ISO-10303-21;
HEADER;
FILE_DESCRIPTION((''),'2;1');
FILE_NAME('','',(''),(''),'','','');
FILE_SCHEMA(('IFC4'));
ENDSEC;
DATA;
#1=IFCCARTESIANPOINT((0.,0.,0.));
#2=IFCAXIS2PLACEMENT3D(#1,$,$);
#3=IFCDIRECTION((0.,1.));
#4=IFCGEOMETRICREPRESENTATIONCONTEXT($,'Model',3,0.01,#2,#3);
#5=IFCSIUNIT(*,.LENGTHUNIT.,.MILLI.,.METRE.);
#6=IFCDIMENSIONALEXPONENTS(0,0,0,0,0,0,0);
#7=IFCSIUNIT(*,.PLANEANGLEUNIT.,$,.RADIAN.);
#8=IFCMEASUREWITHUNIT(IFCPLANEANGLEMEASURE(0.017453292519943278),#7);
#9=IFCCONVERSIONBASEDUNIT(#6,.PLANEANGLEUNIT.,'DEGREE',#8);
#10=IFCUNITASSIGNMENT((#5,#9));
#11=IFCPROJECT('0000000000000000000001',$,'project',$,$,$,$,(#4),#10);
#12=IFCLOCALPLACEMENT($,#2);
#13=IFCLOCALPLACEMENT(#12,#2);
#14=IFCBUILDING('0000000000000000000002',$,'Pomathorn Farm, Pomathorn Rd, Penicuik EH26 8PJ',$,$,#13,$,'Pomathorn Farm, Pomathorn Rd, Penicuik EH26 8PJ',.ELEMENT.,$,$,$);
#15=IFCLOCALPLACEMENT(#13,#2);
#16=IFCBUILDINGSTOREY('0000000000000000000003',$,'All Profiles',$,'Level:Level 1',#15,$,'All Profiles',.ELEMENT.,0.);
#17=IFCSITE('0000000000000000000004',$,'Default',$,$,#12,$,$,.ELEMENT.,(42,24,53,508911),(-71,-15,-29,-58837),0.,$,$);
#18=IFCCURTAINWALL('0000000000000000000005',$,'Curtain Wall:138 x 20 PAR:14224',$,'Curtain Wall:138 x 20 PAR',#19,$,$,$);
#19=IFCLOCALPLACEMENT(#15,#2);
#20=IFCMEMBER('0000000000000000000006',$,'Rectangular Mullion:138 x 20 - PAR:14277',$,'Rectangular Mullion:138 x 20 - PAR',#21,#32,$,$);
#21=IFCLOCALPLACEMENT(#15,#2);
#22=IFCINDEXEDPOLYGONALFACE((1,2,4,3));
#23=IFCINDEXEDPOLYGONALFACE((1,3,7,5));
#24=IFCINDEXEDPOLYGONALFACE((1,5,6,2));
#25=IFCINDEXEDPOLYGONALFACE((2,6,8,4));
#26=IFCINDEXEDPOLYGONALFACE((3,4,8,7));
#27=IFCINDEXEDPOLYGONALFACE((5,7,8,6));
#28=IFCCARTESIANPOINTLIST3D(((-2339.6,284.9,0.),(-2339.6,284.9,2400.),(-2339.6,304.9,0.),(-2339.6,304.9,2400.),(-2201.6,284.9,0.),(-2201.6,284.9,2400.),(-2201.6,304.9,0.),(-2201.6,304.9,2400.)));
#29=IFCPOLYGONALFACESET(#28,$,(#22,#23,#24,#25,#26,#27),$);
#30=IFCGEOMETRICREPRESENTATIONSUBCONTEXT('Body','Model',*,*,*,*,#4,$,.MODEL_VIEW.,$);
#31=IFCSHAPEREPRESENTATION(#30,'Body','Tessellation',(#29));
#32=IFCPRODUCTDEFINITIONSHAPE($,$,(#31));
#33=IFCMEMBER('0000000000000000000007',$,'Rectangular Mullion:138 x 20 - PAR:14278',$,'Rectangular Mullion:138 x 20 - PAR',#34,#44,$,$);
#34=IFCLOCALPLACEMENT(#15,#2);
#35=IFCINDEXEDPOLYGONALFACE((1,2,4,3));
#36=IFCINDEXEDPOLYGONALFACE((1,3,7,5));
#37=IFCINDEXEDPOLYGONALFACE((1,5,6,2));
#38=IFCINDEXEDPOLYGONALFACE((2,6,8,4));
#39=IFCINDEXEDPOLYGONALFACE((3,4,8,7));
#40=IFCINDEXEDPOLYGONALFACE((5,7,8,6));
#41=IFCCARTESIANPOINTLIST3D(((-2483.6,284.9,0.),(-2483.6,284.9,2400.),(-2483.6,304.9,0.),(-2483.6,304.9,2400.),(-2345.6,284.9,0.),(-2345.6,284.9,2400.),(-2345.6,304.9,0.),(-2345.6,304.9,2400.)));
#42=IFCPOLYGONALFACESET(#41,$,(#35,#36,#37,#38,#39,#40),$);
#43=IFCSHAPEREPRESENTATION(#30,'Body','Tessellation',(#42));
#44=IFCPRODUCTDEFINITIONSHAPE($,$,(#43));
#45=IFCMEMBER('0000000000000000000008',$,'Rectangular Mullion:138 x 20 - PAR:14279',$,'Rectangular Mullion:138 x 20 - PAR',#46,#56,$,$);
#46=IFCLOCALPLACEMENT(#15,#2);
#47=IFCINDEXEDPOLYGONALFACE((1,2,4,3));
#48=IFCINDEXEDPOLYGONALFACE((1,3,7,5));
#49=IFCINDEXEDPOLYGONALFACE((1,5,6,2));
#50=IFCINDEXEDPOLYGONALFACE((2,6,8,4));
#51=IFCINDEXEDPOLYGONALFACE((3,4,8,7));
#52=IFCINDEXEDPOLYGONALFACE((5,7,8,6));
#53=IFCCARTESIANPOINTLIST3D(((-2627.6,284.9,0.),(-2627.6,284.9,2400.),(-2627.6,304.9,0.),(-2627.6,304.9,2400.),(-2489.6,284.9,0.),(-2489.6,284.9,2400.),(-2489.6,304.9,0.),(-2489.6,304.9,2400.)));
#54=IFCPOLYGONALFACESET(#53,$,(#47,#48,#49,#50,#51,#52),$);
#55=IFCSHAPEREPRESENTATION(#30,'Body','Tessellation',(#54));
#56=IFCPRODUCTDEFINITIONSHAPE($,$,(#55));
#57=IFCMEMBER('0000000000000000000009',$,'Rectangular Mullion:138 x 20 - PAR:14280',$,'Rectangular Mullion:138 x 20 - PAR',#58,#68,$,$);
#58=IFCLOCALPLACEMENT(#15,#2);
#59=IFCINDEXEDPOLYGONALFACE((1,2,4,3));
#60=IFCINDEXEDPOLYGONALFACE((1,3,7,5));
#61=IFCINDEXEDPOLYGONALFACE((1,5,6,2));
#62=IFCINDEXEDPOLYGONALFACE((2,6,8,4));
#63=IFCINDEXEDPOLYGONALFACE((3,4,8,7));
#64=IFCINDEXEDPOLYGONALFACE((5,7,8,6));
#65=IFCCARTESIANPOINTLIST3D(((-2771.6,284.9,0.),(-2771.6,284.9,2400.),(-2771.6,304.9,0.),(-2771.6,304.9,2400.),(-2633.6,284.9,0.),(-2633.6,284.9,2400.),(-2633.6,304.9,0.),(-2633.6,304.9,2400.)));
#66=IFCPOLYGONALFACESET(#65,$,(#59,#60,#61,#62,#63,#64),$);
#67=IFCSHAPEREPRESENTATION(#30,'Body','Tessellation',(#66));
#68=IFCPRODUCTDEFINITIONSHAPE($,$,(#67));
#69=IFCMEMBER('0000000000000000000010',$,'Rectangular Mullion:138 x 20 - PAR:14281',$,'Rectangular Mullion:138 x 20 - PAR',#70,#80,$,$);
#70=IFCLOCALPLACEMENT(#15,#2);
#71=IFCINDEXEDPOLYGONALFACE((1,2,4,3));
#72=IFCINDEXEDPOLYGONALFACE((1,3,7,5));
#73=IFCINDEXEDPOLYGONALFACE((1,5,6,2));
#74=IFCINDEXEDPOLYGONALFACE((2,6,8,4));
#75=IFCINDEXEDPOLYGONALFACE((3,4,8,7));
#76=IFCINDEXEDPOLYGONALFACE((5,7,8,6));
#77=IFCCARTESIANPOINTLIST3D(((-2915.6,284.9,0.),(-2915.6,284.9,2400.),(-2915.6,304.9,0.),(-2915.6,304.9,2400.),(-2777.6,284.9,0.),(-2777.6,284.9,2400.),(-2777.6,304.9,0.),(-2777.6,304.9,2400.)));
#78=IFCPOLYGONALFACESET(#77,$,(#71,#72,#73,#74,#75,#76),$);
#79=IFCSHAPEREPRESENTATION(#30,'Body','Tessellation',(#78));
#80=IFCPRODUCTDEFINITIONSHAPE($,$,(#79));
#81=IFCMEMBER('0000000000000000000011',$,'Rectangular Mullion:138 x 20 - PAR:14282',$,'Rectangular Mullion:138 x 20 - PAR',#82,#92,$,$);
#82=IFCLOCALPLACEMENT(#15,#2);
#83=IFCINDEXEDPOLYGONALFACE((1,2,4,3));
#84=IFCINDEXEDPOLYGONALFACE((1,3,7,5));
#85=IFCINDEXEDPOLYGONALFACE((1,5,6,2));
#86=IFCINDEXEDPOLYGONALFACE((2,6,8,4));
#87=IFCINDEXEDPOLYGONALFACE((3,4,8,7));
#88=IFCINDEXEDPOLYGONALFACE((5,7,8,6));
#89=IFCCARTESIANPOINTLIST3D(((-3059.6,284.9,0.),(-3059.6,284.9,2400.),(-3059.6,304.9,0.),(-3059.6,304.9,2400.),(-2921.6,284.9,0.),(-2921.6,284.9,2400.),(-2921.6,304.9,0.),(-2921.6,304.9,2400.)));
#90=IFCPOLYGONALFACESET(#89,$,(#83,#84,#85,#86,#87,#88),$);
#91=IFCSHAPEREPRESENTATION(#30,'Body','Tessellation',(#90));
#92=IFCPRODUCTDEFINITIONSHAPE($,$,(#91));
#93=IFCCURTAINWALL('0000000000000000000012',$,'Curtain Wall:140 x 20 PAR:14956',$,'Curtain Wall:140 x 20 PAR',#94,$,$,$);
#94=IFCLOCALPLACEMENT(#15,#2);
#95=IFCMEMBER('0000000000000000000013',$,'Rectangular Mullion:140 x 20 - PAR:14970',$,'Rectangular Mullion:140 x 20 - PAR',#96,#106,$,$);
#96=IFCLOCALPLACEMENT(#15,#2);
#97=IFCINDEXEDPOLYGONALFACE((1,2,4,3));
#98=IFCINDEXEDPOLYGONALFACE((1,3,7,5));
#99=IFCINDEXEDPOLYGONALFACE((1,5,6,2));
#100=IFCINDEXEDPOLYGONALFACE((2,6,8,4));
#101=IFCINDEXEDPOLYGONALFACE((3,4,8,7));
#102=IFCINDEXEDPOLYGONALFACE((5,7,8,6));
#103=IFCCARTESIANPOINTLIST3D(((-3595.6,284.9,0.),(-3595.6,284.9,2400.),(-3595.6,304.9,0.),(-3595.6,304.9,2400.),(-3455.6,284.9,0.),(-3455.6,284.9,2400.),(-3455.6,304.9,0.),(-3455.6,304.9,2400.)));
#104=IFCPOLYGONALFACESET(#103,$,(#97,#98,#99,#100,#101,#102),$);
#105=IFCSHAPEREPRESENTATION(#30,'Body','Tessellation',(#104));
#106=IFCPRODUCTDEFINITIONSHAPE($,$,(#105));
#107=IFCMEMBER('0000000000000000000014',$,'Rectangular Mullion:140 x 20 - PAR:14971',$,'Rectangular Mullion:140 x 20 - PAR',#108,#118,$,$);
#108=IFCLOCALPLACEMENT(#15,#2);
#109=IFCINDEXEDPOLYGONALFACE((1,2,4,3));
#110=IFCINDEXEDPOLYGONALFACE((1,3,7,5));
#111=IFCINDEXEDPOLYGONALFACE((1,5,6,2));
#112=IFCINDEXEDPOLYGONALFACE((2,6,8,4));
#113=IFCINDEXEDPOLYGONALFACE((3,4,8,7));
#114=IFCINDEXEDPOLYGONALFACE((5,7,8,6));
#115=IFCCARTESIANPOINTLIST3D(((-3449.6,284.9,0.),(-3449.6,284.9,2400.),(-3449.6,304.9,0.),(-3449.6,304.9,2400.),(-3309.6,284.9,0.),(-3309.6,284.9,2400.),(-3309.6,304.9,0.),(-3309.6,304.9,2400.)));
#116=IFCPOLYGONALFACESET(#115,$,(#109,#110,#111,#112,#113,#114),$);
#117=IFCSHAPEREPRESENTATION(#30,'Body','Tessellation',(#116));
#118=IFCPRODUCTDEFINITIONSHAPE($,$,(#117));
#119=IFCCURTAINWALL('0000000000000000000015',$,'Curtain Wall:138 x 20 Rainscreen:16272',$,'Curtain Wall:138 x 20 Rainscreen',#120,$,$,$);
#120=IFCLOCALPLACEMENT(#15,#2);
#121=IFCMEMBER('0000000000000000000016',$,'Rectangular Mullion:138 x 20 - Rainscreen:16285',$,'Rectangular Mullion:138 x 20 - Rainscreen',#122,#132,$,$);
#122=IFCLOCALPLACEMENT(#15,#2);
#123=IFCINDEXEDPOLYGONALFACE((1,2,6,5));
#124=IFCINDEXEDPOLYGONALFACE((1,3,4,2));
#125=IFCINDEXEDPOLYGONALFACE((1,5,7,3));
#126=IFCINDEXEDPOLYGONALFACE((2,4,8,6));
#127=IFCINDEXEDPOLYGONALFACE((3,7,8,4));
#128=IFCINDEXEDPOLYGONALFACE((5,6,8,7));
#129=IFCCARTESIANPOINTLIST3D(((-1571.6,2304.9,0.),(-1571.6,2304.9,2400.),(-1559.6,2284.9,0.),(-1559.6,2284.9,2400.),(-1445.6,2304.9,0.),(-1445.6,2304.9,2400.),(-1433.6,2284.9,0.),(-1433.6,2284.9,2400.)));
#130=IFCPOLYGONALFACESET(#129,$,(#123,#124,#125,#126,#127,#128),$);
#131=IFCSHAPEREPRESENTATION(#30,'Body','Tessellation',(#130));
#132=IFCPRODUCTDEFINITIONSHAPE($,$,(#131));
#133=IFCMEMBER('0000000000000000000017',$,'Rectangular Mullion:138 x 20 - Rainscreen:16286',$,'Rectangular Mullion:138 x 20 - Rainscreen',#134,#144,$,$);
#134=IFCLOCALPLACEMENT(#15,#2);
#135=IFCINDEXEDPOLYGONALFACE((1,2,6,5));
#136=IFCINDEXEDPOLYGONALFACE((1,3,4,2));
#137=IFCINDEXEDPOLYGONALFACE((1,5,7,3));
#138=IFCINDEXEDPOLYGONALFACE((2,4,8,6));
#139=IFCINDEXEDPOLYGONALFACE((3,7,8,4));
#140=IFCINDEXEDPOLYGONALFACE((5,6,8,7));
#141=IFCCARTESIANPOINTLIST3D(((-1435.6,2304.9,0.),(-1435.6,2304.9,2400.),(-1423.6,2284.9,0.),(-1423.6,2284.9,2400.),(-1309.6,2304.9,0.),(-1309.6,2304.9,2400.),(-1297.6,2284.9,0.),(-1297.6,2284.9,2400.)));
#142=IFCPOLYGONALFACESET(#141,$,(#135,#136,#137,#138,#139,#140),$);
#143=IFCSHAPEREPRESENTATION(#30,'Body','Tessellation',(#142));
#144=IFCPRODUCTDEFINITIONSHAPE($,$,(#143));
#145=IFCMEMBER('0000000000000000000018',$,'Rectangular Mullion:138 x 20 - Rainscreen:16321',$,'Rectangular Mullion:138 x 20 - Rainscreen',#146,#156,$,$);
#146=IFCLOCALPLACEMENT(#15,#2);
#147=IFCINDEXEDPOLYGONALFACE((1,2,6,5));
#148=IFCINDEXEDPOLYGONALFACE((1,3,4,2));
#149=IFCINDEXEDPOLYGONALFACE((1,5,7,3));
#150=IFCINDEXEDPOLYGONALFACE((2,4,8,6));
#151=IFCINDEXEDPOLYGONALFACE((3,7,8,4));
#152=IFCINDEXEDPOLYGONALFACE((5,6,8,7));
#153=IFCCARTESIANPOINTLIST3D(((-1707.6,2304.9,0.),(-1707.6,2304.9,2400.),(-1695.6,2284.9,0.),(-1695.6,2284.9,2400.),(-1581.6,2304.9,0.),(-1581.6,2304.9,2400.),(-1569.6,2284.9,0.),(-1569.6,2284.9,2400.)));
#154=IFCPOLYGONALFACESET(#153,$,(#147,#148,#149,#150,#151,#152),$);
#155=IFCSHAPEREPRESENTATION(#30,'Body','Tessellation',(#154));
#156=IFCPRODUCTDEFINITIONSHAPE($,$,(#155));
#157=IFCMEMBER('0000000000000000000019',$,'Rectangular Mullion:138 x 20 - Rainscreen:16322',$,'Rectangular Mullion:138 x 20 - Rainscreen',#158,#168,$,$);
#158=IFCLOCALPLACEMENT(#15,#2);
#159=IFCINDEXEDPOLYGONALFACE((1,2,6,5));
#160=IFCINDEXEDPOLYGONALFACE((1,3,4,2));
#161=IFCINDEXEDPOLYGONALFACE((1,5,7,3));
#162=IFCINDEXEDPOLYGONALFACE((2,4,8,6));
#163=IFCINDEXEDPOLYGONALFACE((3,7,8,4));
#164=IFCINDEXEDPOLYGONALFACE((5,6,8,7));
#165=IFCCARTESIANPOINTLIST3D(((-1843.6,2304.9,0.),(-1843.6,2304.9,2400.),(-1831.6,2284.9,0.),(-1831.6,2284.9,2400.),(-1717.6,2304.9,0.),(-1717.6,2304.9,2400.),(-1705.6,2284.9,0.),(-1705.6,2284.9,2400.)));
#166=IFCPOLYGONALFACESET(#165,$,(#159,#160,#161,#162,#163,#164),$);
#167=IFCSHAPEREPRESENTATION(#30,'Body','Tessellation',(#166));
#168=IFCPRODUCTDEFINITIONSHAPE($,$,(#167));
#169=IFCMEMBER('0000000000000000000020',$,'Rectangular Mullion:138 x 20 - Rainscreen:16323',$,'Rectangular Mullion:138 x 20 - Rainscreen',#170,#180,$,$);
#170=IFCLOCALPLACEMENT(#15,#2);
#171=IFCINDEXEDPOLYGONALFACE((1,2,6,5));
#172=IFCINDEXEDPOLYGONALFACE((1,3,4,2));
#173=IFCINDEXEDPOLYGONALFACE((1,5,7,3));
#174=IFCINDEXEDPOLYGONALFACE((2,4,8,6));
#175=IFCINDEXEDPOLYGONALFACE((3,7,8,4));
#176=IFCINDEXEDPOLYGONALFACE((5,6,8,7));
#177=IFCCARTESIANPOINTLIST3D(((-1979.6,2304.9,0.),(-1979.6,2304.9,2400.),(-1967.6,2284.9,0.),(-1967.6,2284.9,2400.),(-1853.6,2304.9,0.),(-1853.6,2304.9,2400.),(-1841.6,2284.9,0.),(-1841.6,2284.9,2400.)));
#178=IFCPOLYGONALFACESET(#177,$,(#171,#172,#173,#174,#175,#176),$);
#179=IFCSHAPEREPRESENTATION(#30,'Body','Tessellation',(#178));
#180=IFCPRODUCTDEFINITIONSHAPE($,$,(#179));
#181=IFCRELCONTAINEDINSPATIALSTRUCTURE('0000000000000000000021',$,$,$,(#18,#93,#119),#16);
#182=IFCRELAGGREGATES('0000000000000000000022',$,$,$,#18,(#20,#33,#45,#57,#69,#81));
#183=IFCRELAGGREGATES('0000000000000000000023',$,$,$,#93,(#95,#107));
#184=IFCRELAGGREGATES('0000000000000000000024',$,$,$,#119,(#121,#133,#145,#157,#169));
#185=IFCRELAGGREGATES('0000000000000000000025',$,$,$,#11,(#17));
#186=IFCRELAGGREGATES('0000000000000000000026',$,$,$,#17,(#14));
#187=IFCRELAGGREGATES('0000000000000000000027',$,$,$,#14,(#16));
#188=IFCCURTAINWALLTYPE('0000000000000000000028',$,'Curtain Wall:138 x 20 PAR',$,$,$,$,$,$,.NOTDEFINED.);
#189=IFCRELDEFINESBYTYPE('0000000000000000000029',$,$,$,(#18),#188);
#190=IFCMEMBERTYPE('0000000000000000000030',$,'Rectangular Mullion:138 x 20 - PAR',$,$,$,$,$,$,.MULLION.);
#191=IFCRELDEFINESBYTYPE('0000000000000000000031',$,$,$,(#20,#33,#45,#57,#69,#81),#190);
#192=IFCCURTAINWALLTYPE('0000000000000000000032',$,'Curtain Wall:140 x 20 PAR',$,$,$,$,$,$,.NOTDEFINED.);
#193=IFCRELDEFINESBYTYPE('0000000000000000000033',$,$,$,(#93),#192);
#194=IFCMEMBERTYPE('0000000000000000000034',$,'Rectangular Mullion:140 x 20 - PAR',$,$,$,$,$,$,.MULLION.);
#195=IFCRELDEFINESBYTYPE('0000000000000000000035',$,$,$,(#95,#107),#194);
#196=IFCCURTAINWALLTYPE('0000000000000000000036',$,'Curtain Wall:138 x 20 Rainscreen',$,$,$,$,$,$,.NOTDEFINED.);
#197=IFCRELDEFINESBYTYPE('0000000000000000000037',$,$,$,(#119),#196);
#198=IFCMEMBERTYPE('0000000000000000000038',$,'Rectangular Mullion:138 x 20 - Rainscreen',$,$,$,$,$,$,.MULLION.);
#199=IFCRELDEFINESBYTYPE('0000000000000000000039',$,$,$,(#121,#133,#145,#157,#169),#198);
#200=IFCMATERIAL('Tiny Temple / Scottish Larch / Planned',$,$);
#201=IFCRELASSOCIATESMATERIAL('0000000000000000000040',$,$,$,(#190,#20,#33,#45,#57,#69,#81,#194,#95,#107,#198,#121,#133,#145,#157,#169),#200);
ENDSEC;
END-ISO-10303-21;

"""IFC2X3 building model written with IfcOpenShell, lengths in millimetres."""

from ifc_helpers import new_model, entity, si_unit, converted_unit, direction, frame, frame_2d, origin, place, context, subcontext, project, spatial, polyline, rectangle, outline, extrude, source, transform, mapped, material, type_object, type_shapes, element, aggregate, save


model = new_model("IFC2X3")

# Units and contexts
model_context = context("Model", 3, precision=0.01, world=origin(), true_north=direction((0.0, 1.0)))
body_context = subcontext(model_context, "Body", "Model", "MODEL_VIEW")
ifc_project = project(units=[si_unit("LENGTHUNIT", "METRE", prefix="MILLI"), converted_unit("PLANEANGLEUNIT", "DEGREE", entity("IfcPlaneAngleMeasure", 0.017453292519943278), si_unit("PLANEANGLEUNIT", "RADIAN"), dimensions=[0, 0, 0, 0, 0, 0, 0])], contexts=[model_context])

# Site, building, storey
site_placement = place(None, origin())
site = spatial("IfcSite", under=ifc_project, at=site_placement, Name="Default", CompositionType="ELEMENT", RefLatitude=(42, 24, 53, 508911), RefLongitude=(-71, -15, -29, -58837), RefElevation=0.0)
building_placement = place(site_placement, origin())
building = spatial("IfcBuilding", under=site, at=building_placement, Name="Pomathorn Farm, Pomathorn Rd, Penicuik EH26 8PJ", LongName="Pomathorn Farm, Pomathorn Rd, Penicuik EH26 8PJ", CompositionType="ELEMENT")
storey_placement = place(building_placement, origin())
storey = spatial("IfcBuildingStorey", under=building, at=storey_placement, Name="All Profiles", ObjectType="Level:Level 1", LongName="All Profiles", CompositionType="ELEMENT", Elevation=0.0)

# Curtain walls, members
curtain_wall_type_1 = type_object("IfcCurtainWallType", Name="Curtain Wall:138 x 20 PAR", PredefinedType="NOTDEFINED")
curtain_wall_1_placement = place(storey_placement, origin())
curtain_wall_1 = element("IfcCurtainWall", 1, at=curtain_wall_1_placement, inside=storey, type_object=curtain_wall_type_1, Name="Curtain Wall:138 x 20 PAR:14224", ObjectType="Curtain Wall:138 x 20 PAR")
ifc_material = material(Name="Tiny Temple / Scottish Larch / Planned")
member_type_1 = type_object("IfcMemberType", Name="Rectangular Mullion:138 x 20 - PAR", PredefinedType="MULLION", material=ifc_material)
shared_shape_1 = source(origin(), body_context, "Body", "SweptSolid", [
    extrude(rectangle(XDim=20.0, YDim=138.0, at=frame_2d((0.0, 0.0), x_axis=(1.0, 0.0))), frame((-69.0, -10.0, -2400.0), z_axis=(0.0, 0.0, 1.0), x_axis=(0.0, 1.0, 0.0)), (0.0, 0.0, 1.0), 2400.0),
])
type_shapes(member_type_1, [shared_shape_1])
member_1_placement = place(curtain_wall_1_placement, frame((-2201.6, 284.9, 0.0), z_axis=(0.0, 0.0, -1.0), x_axis=(1.0, 0.0, 0.0)))
member_1 = element("IfcMember", 2, at=member_1_placement, type_object=member_type_1, material=ifc_material, Name="Rectangular Mullion:138 x 20 - PAR:14277", ObjectType="Rectangular Mullion:138 x 20 - PAR", context=body_context, shape_type="MappedRepresentation", body=[
    mapped(shared_shape_1, transform((0.0, 0.0, 0.0), scale=1.0)),
])
member_2_placement = place(curtain_wall_1_placement, frame((-2345.6, 284.9, 0.0), z_axis=(0.0, 0.0, -1.0), x_axis=(1.0, 0.0, 0.0)))
member_2 = element("IfcMember", 3, at=member_2_placement, type_object=member_type_1, material=ifc_material, Name="Rectangular Mullion:138 x 20 - PAR:14278", ObjectType="Rectangular Mullion:138 x 20 - PAR", context=body_context, shape_type="MappedRepresentation", body=[
    mapped(shared_shape_1, transform((0.0, 0.0, 0.0), scale=1.0)),
])
member_3_placement = place(curtain_wall_1_placement, frame((-2489.6, 284.9, 0.0), z_axis=(0.0, 0.0, -1.0), x_axis=(1.0, 0.0, 0.0)))
member_3 = element("IfcMember", 4, at=member_3_placement, type_object=member_type_1, material=ifc_material, Name="Rectangular Mullion:138 x 20 - PAR:14279", ObjectType="Rectangular Mullion:138 x 20 - PAR", context=body_context, shape_type="MappedRepresentation", body=[
    mapped(shared_shape_1, transform((0.0, 0.0, 0.0), scale=1.0)),
])
member_4_placement = place(curtain_wall_1_placement, frame((-2633.6, 284.9, 0.0), z_axis=(0.0, 0.0, -1.0), x_axis=(1.0, 0.0, 0.0)))
member_4 = element("IfcMember", 5, at=member_4_placement, type_object=member_type_1, material=ifc_material, Name="Rectangular Mullion:138 x 20 - PAR:14280", ObjectType="Rectangular Mullion:138 x 20 - PAR", context=body_context, shape_type="MappedRepresentation", body=[
    mapped(shared_shape_1, transform((0.0, 0.0, 0.0), scale=1.0)),
])
member_5_placement = place(curtain_wall_1_placement, frame((-2777.6, 284.9, 0.0), z_axis=(0.0, 0.0, -1.0), x_axis=(1.0, 0.0, 0.0)))
member_5 = element("IfcMember", 6, at=member_5_placement, type_object=member_type_1, material=ifc_material, Name="Rectangular Mullion:138 x 20 - PAR:14281", ObjectType="Rectangular Mullion:138 x 20 - PAR", context=body_context, shape_type="MappedRepresentation", body=[
    mapped(shared_shape_1, transform((0.0, 0.0, 0.0), scale=1.0)),
])
member_6_placement = place(curtain_wall_1_placement, frame((-2921.6, 284.9, 0.0), z_axis=(0.0, 0.0, -1.0), x_axis=(1.0, 0.0, 0.0)))
member_6 = element("IfcMember", 7, at=member_6_placement, type_object=member_type_1, material=ifc_material, Name="Rectangular Mullion:138 x 20 - PAR:14282", ObjectType="Rectangular Mullion:138 x 20 - PAR", context=body_context, shape_type="MappedRepresentation", body=[
    mapped(shared_shape_1, transform((0.0, 0.0, 0.0), scale=1.0)),
])
aggregate(curtain_wall_1, [member_1, member_2, member_3, member_4, member_5, member_6])
curtain_wall_type_2 = type_object("IfcCurtainWallType", Name="Curtain Wall:140 x 20 PAR", PredefinedType="NOTDEFINED")
curtain_wall_2_placement = place(storey_placement, origin())
curtain_wall_2 = element("IfcCurtainWall", 8, at=curtain_wall_2_placement, inside=storey, type_object=curtain_wall_type_2, Name="Curtain Wall:140 x 20 PAR:14956", ObjectType="Curtain Wall:140 x 20 PAR")
member_type_2 = type_object("IfcMemberType", Name="Rectangular Mullion:140 x 20 - PAR", PredefinedType="MULLION", material=ifc_material)
shared_shape_2 = source(origin(), body_context, "Body", "SweptSolid", [
    extrude(rectangle(XDim=20.0, YDim=140.0, at=frame_2d((0.0, 0.0), x_axis=(1.0, 0.0))), frame((-70.0, -10.0, -2400.0), z_axis=(0.0, 0.0, 1.0), x_axis=(0.0, 1.0, 0.0)), (0.0, 0.0, 1.0), 2400.0),
])
type_shapes(member_type_2, [shared_shape_2])
member_7_placement = place(curtain_wall_2_placement, frame((-3455.6, 284.9, 0.0), z_axis=(0.0, 0.0, -1.0), x_axis=(1.0, 0.0, 0.0)))
member_7 = element("IfcMember", 9, at=member_7_placement, type_object=member_type_2, material=ifc_material, Name="Rectangular Mullion:140 x 20 - PAR:14970", ObjectType="Rectangular Mullion:140 x 20 - PAR", context=body_context, shape_type="MappedRepresentation", body=[
    mapped(shared_shape_2, transform((0.0, 0.0, 0.0), scale=1.0)),
])
member_8_placement = place(curtain_wall_2_placement, frame((-3309.6, 284.9, 0.0), z_axis=(0.0, 0.0, -1.0), x_axis=(1.0, 0.0, 0.0)))
member_8 = element("IfcMember", 10, at=member_8_placement, type_object=member_type_2, material=ifc_material, Name="Rectangular Mullion:140 x 20 - PAR:14971", ObjectType="Rectangular Mullion:140 x 20 - PAR", context=body_context, shape_type="MappedRepresentation", body=[
    mapped(shared_shape_2, transform((0.0, 0.0, 0.0), scale=1.0)),
])
aggregate(curtain_wall_2, [member_7, member_8])
curtain_wall_type_3 = type_object("IfcCurtainWallType", Name="Curtain Wall:138 x 20 Rainscreen", PredefinedType="NOTDEFINED")
curtain_wall_3_placement = place(storey_placement, origin())
curtain_wall_3 = element("IfcCurtainWall", 11, at=curtain_wall_3_placement, inside=storey, type_object=curtain_wall_type_3, Name="Curtain Wall:138 x 20 Rainscreen:16272", ObjectType="Curtain Wall:138 x 20 Rainscreen")
member_type_3 = type_object("IfcMemberType", Name="Rectangular Mullion:138 x 20 - Rainscreen", PredefinedType="MULLION", material=ifc_material)
shared_shape_3 = source(origin(), body_context, "Body", "SweptSolid", [
    extrude(outline(polyline([(20.8, -54.0), (44.1, -54.0), (-20.8, 54.0), (-44.1, 54.0), (20.8, -54.0)])), frame((-69.0, -10.0, -2400.0), z_axis=(0.0, 0.0, 1.0), x_axis=(0.514496, 0.857493, 0.0)), (0.0, 0.0, 1.0), 2400.0),
])
type_shapes(member_type_3, [shared_shape_3])
member_9_placement = place(curtain_wall_3_placement, frame((-1433.6, 2284.9, 0.0), z_axis=(0.0, 0.0, -1.0), x_axis=(1.0, 0.0, 0.0)))
member_9 = element("IfcMember", 12, at=member_9_placement, type_object=member_type_3, material=ifc_material, Name="Rectangular Mullion:138 x 20 - Rainscreen:16285", ObjectType="Rectangular Mullion:138 x 20 - Rainscreen", context=body_context, shape_type="MappedRepresentation", body=[
    mapped(shared_shape_3, transform((0.0, 0.0, 0.0), scale=1.0)),
])
member_10_placement = place(curtain_wall_3_placement, frame((-1297.6, 2284.9, 0.0), z_axis=(0.0, 0.0, -1.0), x_axis=(1.0, 0.0, 0.0)))
member_10 = element("IfcMember", 13, at=member_10_placement, type_object=member_type_3, material=ifc_material, Name="Rectangular Mullion:138 x 20 - Rainscreen:16286", ObjectType="Rectangular Mullion:138 x 20 - Rainscreen", context=body_context, shape_type="MappedRepresentation", body=[
    mapped(shared_shape_3, transform((0.0, 0.0, 0.0), scale=1.0)),
])
member_11_placement = place(curtain_wall_3_placement, frame((-1569.6, 2284.9, 0.0), z_axis=(0.0, 0.0, -1.0), x_axis=(1.0, 0.0, 0.0)))
member_11 = element("IfcMember", 14, at=member_11_placement, type_object=member_type_3, material=ifc_material, Name="Rectangular Mullion:138 x 20 - Rainscreen:16321", ObjectType="Rectangular Mullion:138 x 20 - Rainscreen", context=body_context, shape_type="MappedRepresentation", body=[
    mapped(shared_shape_3, transform((0.0, 0.0, 0.0), scale=1.0)),
])
member_12_placement = place(curtain_wall_3_placement, frame((-1705.6, 2284.9, 0.0), z_axis=(0.0, 0.0, -1.0), x_axis=(1.0, 0.0, 0.0)))
member_12 = element("IfcMember", 15, at=member_12_placement, type_object=member_type_3, material=ifc_material, Name="Rectangular Mullion:138 x 20 - Rainscreen:16322", ObjectType="Rectangular Mullion:138 x 20 - Rainscreen", context=body_context, shape_type="MappedRepresentation", body=[
    mapped(shared_shape_3, transform((0.0, 0.0, 0.0), scale=1.0)),
])
member_13_placement = place(curtain_wall_3_placement, frame((-1841.6, 2284.9, 0.0), z_axis=(0.0, 0.0, -1.0), x_axis=(1.0, 0.0, 0.0)))
member_13 = element("IfcMember", 16, at=member_13_placement, type_object=member_type_3, material=ifc_material, Name="Rectangular Mullion:138 x 20 - Rainscreen:16323", ObjectType="Rectangular Mullion:138 x 20 - Rainscreen", context=body_context, shape_type="MappedRepresentation", body=[
    mapped(shared_shape_3, transform((0.0, 0.0, 0.0), scale=1.0)),
])
aggregate(curtain_wall_3, [member_9, member_10, member_11, member_12, member_13])

save(model, "model.ifc")
